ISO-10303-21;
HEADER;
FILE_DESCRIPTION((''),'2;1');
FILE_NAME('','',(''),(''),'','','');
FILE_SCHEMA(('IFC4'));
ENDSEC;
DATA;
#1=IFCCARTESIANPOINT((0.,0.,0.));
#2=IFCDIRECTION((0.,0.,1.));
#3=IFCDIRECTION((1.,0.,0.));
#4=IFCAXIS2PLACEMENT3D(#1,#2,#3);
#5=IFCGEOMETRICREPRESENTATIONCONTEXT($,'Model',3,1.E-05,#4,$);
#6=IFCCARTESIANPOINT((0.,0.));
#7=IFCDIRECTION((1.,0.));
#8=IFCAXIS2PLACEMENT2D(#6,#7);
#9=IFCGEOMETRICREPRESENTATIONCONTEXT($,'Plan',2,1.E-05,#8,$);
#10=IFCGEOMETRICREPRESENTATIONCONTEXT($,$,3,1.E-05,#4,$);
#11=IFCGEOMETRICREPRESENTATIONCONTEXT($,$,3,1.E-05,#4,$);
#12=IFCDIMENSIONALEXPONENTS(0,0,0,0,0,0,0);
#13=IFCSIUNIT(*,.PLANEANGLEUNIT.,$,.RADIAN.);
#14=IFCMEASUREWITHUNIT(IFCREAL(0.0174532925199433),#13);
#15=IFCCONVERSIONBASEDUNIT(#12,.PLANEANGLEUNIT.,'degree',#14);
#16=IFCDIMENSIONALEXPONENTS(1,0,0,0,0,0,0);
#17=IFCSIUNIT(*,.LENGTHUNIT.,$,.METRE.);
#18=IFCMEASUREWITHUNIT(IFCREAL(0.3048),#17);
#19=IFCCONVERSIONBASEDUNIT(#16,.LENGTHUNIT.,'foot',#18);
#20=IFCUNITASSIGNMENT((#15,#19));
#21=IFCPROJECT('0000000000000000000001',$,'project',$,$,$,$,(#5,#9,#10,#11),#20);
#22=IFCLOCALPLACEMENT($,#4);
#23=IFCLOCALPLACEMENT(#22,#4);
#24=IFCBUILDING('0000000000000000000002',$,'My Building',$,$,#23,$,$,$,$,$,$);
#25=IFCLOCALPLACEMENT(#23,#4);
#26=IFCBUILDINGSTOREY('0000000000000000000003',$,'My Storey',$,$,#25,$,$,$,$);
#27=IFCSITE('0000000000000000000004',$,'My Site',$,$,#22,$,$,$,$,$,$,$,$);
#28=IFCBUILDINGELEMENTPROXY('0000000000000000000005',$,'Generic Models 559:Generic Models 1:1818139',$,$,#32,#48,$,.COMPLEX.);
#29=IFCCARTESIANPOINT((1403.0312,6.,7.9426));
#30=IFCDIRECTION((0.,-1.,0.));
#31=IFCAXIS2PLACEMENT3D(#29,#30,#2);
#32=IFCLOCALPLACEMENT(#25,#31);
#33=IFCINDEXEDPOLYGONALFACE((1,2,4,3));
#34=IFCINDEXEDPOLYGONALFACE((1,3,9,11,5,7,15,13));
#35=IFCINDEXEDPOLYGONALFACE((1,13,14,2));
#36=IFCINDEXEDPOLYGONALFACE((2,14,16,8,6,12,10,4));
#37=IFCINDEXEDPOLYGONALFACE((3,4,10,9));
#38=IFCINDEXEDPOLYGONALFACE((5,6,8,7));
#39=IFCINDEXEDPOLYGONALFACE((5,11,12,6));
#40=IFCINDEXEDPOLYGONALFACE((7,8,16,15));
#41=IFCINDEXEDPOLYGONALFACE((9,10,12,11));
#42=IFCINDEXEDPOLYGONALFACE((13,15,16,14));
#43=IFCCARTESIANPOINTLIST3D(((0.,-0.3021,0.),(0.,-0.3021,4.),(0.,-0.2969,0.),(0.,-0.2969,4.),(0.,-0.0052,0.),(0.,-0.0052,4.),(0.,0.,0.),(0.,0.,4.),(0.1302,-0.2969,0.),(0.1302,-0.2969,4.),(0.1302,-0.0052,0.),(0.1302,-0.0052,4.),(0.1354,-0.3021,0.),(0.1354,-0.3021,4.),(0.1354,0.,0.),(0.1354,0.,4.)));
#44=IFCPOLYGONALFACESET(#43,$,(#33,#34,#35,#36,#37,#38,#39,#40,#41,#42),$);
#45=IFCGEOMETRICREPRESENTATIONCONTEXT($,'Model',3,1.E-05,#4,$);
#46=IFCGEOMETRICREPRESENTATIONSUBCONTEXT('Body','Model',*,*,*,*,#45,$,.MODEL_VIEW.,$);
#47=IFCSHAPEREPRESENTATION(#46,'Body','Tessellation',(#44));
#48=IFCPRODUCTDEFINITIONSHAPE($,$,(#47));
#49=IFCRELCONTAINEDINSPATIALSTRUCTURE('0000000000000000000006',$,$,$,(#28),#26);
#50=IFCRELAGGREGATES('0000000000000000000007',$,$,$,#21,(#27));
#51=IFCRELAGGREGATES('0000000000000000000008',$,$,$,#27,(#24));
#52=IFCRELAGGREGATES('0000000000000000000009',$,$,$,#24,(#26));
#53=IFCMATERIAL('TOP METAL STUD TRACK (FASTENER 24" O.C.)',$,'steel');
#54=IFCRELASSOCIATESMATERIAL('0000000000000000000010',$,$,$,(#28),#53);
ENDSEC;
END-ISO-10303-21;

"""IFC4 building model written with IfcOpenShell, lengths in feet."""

from ifc_helpers import new_model, entity, si_unit, converted_unit, frame, origin_with_axes, origin_2d_with_axis, place, context, subcontext, project, spatial, line, indexed_curve, outline, extrude, material, element, save


model = new_model("IFC4")

# Units and contexts
model_context_1 = context("Model", 3, precision=1e-05, world=origin_with_axes())
plan_context = context("Plan", 2, precision=1e-05, world=origin_2d_with_axis())
model_context_2 = context("Model", 3, precision=1e-05, world=origin_with_axes())
context_of_model_1 = context(None, 3, precision=1e-05, world=origin_with_axes())
context_of_model_2 = context(None, 3, precision=1e-05, world=origin_with_axes())
body_context = subcontext(model_context_2, "Body", "Model", "MODEL_VIEW")
ifc_project = project(units=[converted_unit("PLANEANGLEUNIT", "degree", entity("IfcReal", 0.0174532925199433), si_unit("PLANEANGLEUNIT", "RADIAN"), dimensions=[0, 0, 0, 0, 0, 0, 0]), converted_unit("LENGTHUNIT", "foot", entity("IfcReal", 0.3048), si_unit("LENGTHUNIT", "METRE"), dimensions=[1, 0, 0, 0, 0, 0, 0])], contexts=[model_context_1, plan_context, context_of_model_1, context_of_model_2])

# Site, building, storey
site_placement = place(None, origin_with_axes())
site = spatial("IfcSite", under=ifc_project, at=site_placement, Name="My Site")
building_placement = place(site_placement, origin_with_axes())
building = spatial("IfcBuilding", under=site, at=building_placement, Name="My Building")
storey_placement = place(building_placement, origin_with_axes())
storey = spatial("IfcBuildingStorey", under=building, at=storey_placement, Name="My Storey")

# Building element proxy
ifc_material_1 = material(Name="TOP METAL STUD TRACK (FASTENER 24\" O.C.)", Category="steel")
proxy_1_placement = place(storey_placement, frame((1403.0312, 6.0, 7.9426), z_axis=(0.0, -1.0, 0.0), x_axis=(0.0, 0.0, 1.0)))
element("IfcBuildingElementProxy", 1, at=proxy_1_placement, inside=storey, material=ifc_material_1, Name="Generic Models 559:Generic Models 1:1818139", PredefinedType="COMPLEX", context=body_context, shape_type="SweptSolid", body=[
    extrude(outline(indexed_curve([(-0.069, -0.151), (0.0664, -0.151), (0.0664, -0.1458), (-0.0638, -0.1458), (-0.0638, 0.1458), (0.0664, 0.1458), (0.0664, 0.151), (-0.069, 0.151)], segments=[line(5, 6), line(6, 7), line(7, 8), line(8, 1), line(1, 2), line(2, 3), line(3, 4), line(4, 5)], self_intersect=False)), frame((0.0664, -0.151, 0.0), z_axis=(0.0, 0.0, -1.0), x_axis=(-1.0, 0.0, 0.0)), (0.0, 0.0, -1.0), 4.0),
])

save(model, "model.ifc")
